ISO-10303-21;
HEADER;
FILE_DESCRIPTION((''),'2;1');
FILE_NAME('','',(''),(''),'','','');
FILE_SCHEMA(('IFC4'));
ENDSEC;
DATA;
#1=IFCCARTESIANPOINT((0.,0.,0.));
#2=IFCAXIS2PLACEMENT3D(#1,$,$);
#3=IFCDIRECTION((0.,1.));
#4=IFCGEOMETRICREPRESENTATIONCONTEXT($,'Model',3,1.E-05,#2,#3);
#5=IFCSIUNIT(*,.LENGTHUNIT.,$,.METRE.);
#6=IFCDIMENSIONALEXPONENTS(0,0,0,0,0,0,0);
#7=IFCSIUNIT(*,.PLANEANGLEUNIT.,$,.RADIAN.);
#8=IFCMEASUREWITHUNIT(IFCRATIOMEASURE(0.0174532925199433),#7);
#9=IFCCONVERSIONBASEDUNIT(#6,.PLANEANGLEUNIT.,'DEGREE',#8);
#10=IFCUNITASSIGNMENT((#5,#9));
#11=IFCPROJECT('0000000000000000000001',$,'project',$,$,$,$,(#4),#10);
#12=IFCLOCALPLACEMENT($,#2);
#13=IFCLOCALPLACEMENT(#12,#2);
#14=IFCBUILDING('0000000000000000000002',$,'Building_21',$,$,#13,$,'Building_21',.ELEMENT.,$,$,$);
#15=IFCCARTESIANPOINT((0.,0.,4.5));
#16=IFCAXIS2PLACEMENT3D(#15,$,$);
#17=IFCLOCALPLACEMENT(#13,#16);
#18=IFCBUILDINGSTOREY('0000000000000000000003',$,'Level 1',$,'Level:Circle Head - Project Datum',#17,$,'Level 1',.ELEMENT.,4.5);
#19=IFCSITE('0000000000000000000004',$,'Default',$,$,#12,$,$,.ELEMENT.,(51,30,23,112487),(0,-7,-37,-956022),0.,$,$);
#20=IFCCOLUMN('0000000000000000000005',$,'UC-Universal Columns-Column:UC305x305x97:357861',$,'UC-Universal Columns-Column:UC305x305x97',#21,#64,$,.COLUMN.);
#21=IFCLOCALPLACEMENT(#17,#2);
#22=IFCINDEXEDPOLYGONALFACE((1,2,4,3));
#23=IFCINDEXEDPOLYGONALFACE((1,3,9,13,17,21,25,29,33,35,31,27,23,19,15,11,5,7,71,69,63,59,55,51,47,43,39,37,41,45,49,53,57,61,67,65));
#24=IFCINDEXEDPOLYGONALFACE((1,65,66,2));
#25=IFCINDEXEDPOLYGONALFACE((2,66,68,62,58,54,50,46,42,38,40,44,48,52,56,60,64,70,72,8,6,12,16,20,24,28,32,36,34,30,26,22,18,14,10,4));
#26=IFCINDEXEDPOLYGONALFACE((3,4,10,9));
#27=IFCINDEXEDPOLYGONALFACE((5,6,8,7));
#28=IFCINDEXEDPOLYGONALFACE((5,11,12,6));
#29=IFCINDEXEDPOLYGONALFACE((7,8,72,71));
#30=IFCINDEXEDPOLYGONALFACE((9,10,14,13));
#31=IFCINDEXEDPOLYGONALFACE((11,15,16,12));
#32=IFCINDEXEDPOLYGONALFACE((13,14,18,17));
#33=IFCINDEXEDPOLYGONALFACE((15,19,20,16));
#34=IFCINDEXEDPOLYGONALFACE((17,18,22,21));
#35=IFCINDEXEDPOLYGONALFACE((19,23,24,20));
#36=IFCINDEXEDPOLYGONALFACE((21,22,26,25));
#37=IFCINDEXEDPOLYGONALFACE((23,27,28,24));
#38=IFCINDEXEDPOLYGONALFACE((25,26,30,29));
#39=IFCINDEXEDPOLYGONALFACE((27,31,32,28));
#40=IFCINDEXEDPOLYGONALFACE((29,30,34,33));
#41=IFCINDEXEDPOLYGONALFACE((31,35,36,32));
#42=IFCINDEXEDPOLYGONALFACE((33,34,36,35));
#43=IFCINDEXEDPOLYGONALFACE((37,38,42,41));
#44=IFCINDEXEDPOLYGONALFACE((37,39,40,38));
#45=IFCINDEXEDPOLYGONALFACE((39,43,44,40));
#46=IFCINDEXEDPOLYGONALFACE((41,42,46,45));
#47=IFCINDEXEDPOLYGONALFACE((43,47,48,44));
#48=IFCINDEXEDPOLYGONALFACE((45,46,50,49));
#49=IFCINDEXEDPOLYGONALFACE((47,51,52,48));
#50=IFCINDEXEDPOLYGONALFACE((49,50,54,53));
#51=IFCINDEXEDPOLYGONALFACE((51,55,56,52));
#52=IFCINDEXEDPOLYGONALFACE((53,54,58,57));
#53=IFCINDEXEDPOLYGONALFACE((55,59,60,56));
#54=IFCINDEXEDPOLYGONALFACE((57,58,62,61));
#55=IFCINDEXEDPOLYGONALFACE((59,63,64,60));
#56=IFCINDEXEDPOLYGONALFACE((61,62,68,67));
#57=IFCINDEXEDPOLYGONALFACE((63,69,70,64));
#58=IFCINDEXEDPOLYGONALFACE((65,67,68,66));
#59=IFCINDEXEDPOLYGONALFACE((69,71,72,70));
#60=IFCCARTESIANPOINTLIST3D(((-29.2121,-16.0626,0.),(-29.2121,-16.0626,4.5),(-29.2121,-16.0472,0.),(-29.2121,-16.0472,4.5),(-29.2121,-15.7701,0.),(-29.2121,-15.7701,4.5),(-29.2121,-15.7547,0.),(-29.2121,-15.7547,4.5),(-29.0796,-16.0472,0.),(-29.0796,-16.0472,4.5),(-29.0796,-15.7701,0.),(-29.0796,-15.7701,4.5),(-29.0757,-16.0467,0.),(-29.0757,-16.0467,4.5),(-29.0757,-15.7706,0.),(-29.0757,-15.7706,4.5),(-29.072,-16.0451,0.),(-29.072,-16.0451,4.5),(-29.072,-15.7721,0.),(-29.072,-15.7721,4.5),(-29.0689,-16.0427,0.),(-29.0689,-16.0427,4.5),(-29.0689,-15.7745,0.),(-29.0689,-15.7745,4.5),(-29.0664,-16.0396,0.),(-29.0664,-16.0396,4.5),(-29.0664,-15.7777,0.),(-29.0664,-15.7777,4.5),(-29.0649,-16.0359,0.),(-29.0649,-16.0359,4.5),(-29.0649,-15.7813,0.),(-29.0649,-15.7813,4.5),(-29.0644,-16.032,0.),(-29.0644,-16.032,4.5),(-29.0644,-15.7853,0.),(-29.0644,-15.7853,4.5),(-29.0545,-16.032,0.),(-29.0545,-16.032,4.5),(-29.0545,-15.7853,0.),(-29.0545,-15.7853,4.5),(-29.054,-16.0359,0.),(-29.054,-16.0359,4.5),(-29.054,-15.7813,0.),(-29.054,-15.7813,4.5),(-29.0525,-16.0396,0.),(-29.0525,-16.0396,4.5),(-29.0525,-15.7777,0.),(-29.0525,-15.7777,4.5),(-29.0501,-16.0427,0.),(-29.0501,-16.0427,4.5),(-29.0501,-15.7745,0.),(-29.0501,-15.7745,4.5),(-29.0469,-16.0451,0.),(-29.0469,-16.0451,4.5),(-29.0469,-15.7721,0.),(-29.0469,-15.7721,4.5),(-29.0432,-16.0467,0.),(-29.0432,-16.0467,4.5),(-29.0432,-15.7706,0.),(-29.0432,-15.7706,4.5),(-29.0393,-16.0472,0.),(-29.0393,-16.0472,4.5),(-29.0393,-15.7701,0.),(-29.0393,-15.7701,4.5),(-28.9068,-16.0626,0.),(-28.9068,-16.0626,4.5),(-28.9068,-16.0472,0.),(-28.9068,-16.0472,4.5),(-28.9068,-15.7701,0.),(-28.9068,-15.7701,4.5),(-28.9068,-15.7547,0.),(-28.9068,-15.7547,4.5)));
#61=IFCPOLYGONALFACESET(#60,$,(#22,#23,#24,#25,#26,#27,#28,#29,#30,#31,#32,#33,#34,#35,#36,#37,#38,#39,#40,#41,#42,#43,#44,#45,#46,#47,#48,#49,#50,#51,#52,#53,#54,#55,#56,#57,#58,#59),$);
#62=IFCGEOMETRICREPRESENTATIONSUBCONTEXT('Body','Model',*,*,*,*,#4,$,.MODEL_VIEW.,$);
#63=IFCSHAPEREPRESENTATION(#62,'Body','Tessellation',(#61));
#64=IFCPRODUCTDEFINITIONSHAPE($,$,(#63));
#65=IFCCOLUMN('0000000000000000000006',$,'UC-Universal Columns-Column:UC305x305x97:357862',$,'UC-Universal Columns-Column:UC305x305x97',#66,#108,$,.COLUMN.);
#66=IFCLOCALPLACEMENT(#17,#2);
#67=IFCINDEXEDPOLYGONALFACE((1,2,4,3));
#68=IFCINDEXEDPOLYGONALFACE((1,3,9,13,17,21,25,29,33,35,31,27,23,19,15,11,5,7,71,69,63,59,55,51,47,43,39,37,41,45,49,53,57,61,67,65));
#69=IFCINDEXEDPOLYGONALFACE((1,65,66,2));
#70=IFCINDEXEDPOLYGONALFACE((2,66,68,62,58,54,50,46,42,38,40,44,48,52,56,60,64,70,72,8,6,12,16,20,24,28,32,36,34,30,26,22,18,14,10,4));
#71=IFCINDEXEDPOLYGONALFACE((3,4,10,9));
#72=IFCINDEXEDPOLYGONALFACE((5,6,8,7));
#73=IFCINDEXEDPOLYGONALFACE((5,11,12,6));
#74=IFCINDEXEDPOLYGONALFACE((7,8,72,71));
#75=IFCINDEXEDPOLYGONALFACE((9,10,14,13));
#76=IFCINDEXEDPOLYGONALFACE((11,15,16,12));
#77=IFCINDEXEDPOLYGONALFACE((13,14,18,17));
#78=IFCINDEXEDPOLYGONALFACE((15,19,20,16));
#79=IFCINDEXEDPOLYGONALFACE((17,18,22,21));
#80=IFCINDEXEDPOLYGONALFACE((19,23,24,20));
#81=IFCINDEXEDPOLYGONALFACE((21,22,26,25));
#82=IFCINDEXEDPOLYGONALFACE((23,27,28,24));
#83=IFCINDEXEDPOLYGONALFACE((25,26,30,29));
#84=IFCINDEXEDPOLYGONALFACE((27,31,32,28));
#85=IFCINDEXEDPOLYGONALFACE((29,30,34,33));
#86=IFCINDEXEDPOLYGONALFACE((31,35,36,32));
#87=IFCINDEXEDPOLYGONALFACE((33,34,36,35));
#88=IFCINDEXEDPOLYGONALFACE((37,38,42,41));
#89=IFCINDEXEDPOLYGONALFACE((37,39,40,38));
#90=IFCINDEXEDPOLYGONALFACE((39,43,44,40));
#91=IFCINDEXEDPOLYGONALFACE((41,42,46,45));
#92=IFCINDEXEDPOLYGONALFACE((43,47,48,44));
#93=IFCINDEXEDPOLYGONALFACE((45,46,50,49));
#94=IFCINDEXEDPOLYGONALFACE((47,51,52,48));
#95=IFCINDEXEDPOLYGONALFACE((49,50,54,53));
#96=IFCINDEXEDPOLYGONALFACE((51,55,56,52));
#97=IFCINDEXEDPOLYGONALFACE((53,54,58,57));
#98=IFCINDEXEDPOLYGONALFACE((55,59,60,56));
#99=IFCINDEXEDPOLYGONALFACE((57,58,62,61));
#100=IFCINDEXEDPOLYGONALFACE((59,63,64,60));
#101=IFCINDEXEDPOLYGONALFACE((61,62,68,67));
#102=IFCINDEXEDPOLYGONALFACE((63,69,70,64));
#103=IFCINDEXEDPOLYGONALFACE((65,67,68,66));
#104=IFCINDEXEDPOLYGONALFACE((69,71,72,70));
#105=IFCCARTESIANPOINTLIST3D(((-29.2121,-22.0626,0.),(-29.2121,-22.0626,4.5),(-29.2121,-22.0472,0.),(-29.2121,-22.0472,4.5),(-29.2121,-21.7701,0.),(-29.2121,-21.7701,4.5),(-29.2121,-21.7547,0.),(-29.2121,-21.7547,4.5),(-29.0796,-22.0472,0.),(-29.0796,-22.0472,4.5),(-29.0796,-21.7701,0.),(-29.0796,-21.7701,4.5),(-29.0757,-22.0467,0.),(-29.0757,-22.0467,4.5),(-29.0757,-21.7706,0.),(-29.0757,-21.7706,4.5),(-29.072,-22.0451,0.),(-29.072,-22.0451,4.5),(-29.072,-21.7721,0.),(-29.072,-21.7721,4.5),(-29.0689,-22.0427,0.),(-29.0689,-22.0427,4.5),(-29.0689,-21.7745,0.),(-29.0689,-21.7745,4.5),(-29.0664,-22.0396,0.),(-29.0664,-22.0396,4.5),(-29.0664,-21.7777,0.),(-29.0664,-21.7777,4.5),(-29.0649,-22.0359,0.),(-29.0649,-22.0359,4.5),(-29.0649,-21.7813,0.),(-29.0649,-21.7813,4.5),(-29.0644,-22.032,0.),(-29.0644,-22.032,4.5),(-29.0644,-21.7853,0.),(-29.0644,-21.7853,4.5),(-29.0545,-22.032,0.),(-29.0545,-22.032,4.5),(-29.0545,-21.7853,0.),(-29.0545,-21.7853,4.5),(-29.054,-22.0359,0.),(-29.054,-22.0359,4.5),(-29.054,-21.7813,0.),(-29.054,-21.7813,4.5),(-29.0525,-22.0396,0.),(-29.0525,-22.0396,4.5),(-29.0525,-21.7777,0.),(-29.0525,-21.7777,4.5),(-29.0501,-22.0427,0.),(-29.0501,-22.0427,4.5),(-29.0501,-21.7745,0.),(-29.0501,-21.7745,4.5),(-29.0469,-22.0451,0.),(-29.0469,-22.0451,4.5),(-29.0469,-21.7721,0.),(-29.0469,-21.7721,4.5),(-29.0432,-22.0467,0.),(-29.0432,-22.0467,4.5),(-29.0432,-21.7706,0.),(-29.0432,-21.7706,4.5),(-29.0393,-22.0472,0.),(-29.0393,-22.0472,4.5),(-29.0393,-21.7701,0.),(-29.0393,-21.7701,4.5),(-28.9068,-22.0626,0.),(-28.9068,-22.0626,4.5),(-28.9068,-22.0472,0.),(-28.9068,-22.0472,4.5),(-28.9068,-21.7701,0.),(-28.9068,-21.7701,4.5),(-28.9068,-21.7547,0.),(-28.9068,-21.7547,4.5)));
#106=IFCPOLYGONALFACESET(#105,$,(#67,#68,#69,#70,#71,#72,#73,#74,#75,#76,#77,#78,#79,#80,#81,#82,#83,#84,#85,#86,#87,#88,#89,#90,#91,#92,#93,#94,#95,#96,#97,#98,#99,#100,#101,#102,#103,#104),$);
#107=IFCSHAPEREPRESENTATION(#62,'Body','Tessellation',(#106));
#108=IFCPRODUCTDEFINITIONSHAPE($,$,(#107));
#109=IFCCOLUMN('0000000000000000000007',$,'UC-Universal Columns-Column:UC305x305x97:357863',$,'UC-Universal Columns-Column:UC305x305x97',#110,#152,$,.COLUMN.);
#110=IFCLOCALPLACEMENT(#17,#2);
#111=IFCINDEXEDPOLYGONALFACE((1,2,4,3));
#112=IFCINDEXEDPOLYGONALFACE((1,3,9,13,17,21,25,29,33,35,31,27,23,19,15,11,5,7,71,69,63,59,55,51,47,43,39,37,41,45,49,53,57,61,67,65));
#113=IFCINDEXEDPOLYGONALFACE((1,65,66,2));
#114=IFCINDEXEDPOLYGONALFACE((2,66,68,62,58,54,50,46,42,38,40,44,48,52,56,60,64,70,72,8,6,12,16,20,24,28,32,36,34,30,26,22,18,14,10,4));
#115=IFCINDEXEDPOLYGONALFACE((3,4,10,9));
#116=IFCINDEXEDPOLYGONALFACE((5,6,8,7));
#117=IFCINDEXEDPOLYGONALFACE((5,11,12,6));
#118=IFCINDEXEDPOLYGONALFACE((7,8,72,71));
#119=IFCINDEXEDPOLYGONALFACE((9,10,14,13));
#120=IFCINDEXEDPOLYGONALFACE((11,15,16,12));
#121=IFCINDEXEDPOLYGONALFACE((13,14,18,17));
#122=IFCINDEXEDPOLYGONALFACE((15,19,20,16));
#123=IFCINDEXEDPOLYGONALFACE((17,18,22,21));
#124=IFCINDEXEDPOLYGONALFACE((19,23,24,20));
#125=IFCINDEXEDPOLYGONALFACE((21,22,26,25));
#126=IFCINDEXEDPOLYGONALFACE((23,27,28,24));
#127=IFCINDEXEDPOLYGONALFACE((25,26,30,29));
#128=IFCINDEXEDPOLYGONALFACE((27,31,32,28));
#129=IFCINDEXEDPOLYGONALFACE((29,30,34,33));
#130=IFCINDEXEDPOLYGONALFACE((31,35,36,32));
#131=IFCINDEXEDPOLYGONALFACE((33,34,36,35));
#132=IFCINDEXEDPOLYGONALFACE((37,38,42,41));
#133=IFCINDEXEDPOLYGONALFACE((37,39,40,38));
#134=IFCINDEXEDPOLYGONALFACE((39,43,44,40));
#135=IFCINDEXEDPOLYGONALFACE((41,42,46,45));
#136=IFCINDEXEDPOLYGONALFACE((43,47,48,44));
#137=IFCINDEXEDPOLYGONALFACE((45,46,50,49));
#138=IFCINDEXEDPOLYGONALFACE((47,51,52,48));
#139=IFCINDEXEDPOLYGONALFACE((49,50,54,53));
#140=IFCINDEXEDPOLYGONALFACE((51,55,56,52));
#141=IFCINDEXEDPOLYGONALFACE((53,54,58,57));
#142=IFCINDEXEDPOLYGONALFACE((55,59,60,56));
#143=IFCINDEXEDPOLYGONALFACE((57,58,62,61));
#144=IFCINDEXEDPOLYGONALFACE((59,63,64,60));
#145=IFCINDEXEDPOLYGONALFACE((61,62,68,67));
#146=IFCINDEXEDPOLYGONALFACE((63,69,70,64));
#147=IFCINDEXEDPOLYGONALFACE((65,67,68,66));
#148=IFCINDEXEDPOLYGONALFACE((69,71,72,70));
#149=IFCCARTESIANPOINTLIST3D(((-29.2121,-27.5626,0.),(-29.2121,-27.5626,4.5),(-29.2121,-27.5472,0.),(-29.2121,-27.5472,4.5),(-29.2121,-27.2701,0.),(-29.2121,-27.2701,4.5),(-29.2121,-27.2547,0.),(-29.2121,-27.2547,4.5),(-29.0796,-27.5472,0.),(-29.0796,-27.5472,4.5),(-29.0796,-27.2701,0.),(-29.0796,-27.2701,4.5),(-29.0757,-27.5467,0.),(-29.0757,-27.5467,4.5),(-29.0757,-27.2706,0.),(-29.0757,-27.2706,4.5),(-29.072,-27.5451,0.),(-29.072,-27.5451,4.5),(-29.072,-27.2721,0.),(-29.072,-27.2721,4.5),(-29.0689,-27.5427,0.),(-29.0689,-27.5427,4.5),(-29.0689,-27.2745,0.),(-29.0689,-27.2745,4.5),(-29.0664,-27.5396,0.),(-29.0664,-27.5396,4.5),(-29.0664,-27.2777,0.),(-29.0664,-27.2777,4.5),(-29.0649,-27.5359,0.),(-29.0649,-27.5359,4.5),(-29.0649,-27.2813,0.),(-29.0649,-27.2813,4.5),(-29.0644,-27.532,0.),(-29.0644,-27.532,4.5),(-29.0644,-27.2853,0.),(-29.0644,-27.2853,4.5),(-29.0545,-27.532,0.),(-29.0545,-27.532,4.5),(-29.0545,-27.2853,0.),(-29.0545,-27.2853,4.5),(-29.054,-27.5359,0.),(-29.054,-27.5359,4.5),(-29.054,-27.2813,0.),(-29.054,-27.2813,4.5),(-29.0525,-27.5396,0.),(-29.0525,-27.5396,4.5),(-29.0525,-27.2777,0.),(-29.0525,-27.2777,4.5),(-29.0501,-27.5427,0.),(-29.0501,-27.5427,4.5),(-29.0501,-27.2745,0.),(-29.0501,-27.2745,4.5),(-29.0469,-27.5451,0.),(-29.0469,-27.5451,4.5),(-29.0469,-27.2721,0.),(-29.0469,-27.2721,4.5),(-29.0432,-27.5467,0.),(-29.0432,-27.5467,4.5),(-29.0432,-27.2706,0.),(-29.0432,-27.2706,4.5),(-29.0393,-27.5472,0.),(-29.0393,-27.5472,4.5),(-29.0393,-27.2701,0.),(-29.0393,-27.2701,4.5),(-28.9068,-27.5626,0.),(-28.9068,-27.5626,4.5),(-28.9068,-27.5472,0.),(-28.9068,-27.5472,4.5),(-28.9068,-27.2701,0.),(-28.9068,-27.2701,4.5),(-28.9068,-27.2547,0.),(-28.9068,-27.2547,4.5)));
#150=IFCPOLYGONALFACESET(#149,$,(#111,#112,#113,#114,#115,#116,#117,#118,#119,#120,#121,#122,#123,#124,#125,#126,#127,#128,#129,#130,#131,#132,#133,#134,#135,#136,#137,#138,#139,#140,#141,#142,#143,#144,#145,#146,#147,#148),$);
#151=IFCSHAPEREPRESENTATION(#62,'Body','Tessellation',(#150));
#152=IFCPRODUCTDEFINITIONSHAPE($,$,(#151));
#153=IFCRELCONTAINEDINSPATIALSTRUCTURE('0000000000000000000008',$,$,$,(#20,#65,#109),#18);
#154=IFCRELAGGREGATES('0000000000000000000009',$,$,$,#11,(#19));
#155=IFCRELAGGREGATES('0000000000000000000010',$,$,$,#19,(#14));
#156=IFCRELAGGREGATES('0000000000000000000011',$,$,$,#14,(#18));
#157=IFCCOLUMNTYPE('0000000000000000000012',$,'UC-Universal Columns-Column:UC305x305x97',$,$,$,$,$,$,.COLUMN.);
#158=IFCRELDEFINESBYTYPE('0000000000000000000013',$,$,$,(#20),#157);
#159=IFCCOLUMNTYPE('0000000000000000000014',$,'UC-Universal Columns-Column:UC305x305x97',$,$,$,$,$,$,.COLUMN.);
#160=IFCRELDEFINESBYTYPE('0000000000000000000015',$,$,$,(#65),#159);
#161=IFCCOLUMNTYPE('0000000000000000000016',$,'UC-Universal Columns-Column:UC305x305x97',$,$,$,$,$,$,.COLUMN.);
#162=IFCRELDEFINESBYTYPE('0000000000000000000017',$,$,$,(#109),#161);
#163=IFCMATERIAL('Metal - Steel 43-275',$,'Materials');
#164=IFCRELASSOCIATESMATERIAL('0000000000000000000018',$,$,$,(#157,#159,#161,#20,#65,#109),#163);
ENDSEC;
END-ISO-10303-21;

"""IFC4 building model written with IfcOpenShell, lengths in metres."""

from ifc_helpers import new_model, entity, si_unit, converted_unit, direction, frame, frame_2d, origin, place, context, subcontext, project, spatial, polyline, circle_curve, parameter, trimmed, segment, composite_curve, i_section, outline, extrude, source, transform, mapped, material, material_profile, profile_set, profile_usage, type_object, type_shapes, element, save


model = new_model("IFC4")

# Units and contexts
model_context = context("Model", 3, precision=1e-05, world=origin(), true_north=direction((0.0, 1.0)))
body_context = subcontext(model_context, "Body", "Model", "MODEL_VIEW")
ifc_project = project(units=[si_unit("LENGTHUNIT", "METRE"), converted_unit("PLANEANGLEUNIT", "DEGREE", entity("IfcRatioMeasure", 0.0174532925199433), si_unit("PLANEANGLEUNIT", "RADIAN"), dimensions=[0, 0, 0, 0, 0, 0, 0])], contexts=[model_context])

# Site, building, storey
site_placement = place(None, origin())
site = spatial("IfcSite", under=ifc_project, at=site_placement, Name="Default", CompositionType="ELEMENT", RefLatitude=(51, 30, 23, 112487), RefLongitude=(0, -7, -37, -956022), RefElevation=0.0)
building_placement = place(site_placement, origin())
building = spatial("IfcBuilding", under=site, at=building_placement, Name="Building_21", LongName="Building_21", CompositionType="ELEMENT")
storey_placement = place(building_placement, frame((0.0, 0.0, 4.5)))
storey = spatial("IfcBuildingStorey", under=building, at=storey_placement, Name="Level 1", ObjectType="Level:Circle Head - Project Datum", LongName="Level 1", CompositionType="ELEMENT", Elevation=4.5)

# Columns
ifc_material_1 = material(Name="Metal - Steel 43-275", Category="Materials")
ifc_material_profile_1 = material_profile(ifc_material_1, outline(composite_curve([segment(polyline([(-0.1527, 0.154, 0.0), (0.1527, 0.154, 0.0)]), True, "CONTINUOUS"), segment(polyline([(0.1527, 0.154, 0.0), (0.1527, 0.1386, 0.0)]), True, "CONTINUOUS"), segment(polyline([(0.1527, 0.1386, 0.0), (0.0201, 0.1386, 0.0)]), True, "CONTINUOUS"), segment(trimmed(circle_curve(frame((0.0201, 0.1234, 0.0)), 0.0152), [parameter(90.0)], [parameter(180.0)], True, "PARAMETER"), True, "CONTINUOUS"), segment(polyline([(0.0049, 0.1234, 0.0), (0.0049, -0.1234, 0.0)]), True, "CONTINUOUS"), segment(trimmed(circle_curve(frame((0.0201, -0.1234, 0.0)), 0.0152), [parameter(180.0)], [parameter(270.0)], True, "PARAMETER"), True, "CONTINUOUS"), segment(polyline([(0.0201, -0.1386, 0.0), (0.1527, -0.1386, 0.0)]), True, "CONTINUOUS"), segment(polyline([(0.1527, -0.1386, 0.0), (0.1527, -0.154, 0.0)]), True, "CONTINUOUS"), segment(polyline([(0.1527, -0.154, 0.0), (-0.1527, -0.154, 0.0)]), True, "CONTINUOUS"), segment(polyline([(-0.1527, -0.154, 0.0), (-0.1527, -0.1386, 0.0)]), True, "CONTINUOUS"), segment(polyline([(-0.1527, -0.1386, 0.0), (-0.0201, -0.1386, 0.0)]), True, "CONTINUOUS"), segment(trimmed(circle_curve(frame((-0.0201, -0.1234, 0.0)), 0.0152), [parameter(270.0)], [parameter(0.0)], True, "PARAMETER"), True, "CONTINUOUS"), segment(polyline([(-0.0049, -0.1234, 0.0), (-0.005, 0.1234, 0.0)]), True, "CONTINUOUS"), segment(trimmed(circle_curve(frame((-0.0201, 0.1234, 0.0)), 0.0152), [parameter(0.0)], [parameter(90.0)], True, "PARAMETER"), True, "CONTINUOUS"), segment(polyline([(-0.0201, 0.1386, 0.0), (-0.1527, 0.1386, 0.0)]), True, "CONTINUOUS"), segment(polyline([(-0.1527, 0.1386, 0.0), (-0.1527, 0.154, 0.0)]), True, "CONTINUOUS")], self_intersect=False), kind="CURVE"), Name="UC305x305x97")
ifc_material_profile_2 = material_profile(ifc_material_1, outline(composite_curve([segment(polyline([(0.1527, 0.154, 0.0), (0.1527, 0.1386, 0.0)]), True, "CONTINUOUS"), segment(polyline([(0.1527, 0.1386, 0.0), (0.0049, 0.1386, 0.0)]), True, "CONTINUOUS"), segment(polyline([(0.0049, 0.1386, 0.0), (0.0049, -0.1386, 0.0)]), True, "CONTINUOUS"), segment(polyline([(0.0049, -0.1386, 0.0), (0.1527, -0.1386, 0.0)]), True, "CONTINUOUS"), segment(polyline([(0.1527, -0.1386, 0.0), (0.1527, -0.154, 0.0)]), True, "CONTINUOUS"), segment(polyline([(0.1527, -0.154, 0.0), (-0.1527, -0.154, 0.0)]), True, "CONTINUOUS"), segment(polyline([(-0.1527, -0.154, 0.0), (-0.1527, -0.1386, 0.0)]), True, "CONTINUOUS"), segment(polyline([(-0.1527, -0.1386, 0.0), (-0.005, -0.1386, 0.0)]), True, "CONTINUOUS"), segment(polyline([(-0.005, -0.1386, 0.0), (-0.005, 0.1386, 0.0)]), True, "CONTINUOUS"), segment(polyline([(-0.005, 0.1386, 0.0), (-0.1527, 0.1386, 0.0)]), True, "CONTINUOUS"), segment(polyline([(-0.1527, 0.1386, 0.0), (-0.1527, 0.154, 0.0)]), True, "CONTINUOUS"), segment(polyline([(-0.1527, 0.154, 0.0), (0.1527, 0.154, 0.0)]), True, "CONTINUOUS")], self_intersect=False), kind="CURVE"), Name="UC305x305x97")
ifc_profile_set_1 = profile_set([ifc_material_profile_1, ifc_material_profile_2], Name="UC305x305x97")
ifc_profile_usage_1 = profile_usage(ifc_profile_set_1)
column_type_1 = type_object("IfcColumnType", Name="UC-Universal Columns-Column:UC305x305x97", PredefinedType="COLUMN", material=ifc_profile_set_1)
shared_shape_1 = source(origin(), body_context, "Body", "SweptSolid", [
    extrude(i_section(OverallWidth=0.3053, OverallDepth=0.3079, WebThickness=0.0099, FlangeThickness=0.0154, FilletRadius=0.0152, at=frame_2d((0.0, 0.0), x_axis=(0.0, 1.0))), frame((-29.0595, -15.9086, 4.5), z_axis=(0.0, 0.0, 1.0), x_axis=(0.0, -1.0, 0.0)), (0.0, 0.0, 1.0), 4.5),
])
type_shapes(column_type_1, [shared_shape_1])
column_1_placement = place(storey_placement, frame((0.0, 0.0, -4.5)))
element("IfcColumn", 1, at=column_1_placement, inside=storey, type_object=column_type_1, material=ifc_profile_usage_1, Name="UC-Universal Columns-Column:UC305x305x97:357861", ObjectType="UC-Universal Columns-Column:UC305x305x97", PredefinedType="COLUMN", context=body_context, shape_type="MappedRepresentation", body=[
    mapped(shared_shape_1, transform((0.0, 0.0, 0.0), scale=1.0)),
])
ifc_profile_usage_2 = profile_usage(ifc_profile_set_1)
column_type_2 = type_object("IfcColumnType", Name="UC-Universal Columns-Column:UC305x305x97", PredefinedType="COLUMN", material=ifc_profile_set_1)
shared_shape_2 = source(origin(), body_context, "Body", "SweptSolid", [
    extrude(i_section(OverallWidth=0.3053, OverallDepth=0.3079, WebThickness=0.0099, FlangeThickness=0.0154, FilletRadius=0.0152, at=frame_2d((0.0, 0.0), x_axis=(0.0, 1.0))), frame((-29.0595, -21.9086, 4.5), z_axis=(0.0, 0.0, 1.0), x_axis=(0.0, -1.0, 0.0)), (0.0, 0.0, 1.0), 4.5),
])
type_shapes(column_type_2, [shared_shape_2])
column_2_placement = place(storey_placement, frame((0.0, 0.0, -4.5)))
element("IfcColumn", 2, at=column_2_placement, inside=storey, type_object=column_type_2, material=ifc_profile_usage_2, Name="UC-Universal Columns-Column:UC305x305x97:357862", ObjectType="UC-Universal Columns-Column:UC305x305x97", PredefinedType="COLUMN", context=body_context, shape_type="MappedRepresentation", body=[
    mapped(shared_shape_2, transform((0.0, 0.0, 0.0), scale=1.0)),
])
ifc_profile_usage_3 = profile_usage(ifc_profile_set_1)
column_type_3 = type_object("IfcColumnType", Name="UC-Universal Columns-Column:UC305x305x97", PredefinedType="COLUMN", material=ifc_profile_set_1)
shared_shape_3 = source(origin(), body_context, "Body", "SweptSolid", [
    extrude(i_section(OverallWidth=0.3053, OverallDepth=0.3079, WebThickness=0.0099, FlangeThickness=0.0154, FilletRadius=0.0152, at=frame_2d((0.0, 0.0), x_axis=(0.0, 1.0))), frame((-29.0595, -27.4086, 4.5), z_axis=(0.0, 0.0, 1.0), x_axis=(0.0, -1.0, 0.0)), (0.0, 0.0, 1.0), 4.5),
])
type_shapes(column_type_3, [shared_shape_3])
column_3_placement = place(storey_placement, frame((0.0, 0.0, -4.5)))
element("IfcColumn", 3, at=column_3_placement, inside=storey, type_object=column_type_3, material=ifc_profile_usage_3, Name="UC-Universal Columns-Column:UC305x305x97:357863", ObjectType="UC-Universal Columns-Column:UC305x305x97", PredefinedType="COLUMN", context=body_context, shape_type="MappedRepresentation", body=[
    mapped(shared_shape_3, transform((0.0, 0.0, 0.0), scale=1.0)),
])

save(model, "model.ifc")
